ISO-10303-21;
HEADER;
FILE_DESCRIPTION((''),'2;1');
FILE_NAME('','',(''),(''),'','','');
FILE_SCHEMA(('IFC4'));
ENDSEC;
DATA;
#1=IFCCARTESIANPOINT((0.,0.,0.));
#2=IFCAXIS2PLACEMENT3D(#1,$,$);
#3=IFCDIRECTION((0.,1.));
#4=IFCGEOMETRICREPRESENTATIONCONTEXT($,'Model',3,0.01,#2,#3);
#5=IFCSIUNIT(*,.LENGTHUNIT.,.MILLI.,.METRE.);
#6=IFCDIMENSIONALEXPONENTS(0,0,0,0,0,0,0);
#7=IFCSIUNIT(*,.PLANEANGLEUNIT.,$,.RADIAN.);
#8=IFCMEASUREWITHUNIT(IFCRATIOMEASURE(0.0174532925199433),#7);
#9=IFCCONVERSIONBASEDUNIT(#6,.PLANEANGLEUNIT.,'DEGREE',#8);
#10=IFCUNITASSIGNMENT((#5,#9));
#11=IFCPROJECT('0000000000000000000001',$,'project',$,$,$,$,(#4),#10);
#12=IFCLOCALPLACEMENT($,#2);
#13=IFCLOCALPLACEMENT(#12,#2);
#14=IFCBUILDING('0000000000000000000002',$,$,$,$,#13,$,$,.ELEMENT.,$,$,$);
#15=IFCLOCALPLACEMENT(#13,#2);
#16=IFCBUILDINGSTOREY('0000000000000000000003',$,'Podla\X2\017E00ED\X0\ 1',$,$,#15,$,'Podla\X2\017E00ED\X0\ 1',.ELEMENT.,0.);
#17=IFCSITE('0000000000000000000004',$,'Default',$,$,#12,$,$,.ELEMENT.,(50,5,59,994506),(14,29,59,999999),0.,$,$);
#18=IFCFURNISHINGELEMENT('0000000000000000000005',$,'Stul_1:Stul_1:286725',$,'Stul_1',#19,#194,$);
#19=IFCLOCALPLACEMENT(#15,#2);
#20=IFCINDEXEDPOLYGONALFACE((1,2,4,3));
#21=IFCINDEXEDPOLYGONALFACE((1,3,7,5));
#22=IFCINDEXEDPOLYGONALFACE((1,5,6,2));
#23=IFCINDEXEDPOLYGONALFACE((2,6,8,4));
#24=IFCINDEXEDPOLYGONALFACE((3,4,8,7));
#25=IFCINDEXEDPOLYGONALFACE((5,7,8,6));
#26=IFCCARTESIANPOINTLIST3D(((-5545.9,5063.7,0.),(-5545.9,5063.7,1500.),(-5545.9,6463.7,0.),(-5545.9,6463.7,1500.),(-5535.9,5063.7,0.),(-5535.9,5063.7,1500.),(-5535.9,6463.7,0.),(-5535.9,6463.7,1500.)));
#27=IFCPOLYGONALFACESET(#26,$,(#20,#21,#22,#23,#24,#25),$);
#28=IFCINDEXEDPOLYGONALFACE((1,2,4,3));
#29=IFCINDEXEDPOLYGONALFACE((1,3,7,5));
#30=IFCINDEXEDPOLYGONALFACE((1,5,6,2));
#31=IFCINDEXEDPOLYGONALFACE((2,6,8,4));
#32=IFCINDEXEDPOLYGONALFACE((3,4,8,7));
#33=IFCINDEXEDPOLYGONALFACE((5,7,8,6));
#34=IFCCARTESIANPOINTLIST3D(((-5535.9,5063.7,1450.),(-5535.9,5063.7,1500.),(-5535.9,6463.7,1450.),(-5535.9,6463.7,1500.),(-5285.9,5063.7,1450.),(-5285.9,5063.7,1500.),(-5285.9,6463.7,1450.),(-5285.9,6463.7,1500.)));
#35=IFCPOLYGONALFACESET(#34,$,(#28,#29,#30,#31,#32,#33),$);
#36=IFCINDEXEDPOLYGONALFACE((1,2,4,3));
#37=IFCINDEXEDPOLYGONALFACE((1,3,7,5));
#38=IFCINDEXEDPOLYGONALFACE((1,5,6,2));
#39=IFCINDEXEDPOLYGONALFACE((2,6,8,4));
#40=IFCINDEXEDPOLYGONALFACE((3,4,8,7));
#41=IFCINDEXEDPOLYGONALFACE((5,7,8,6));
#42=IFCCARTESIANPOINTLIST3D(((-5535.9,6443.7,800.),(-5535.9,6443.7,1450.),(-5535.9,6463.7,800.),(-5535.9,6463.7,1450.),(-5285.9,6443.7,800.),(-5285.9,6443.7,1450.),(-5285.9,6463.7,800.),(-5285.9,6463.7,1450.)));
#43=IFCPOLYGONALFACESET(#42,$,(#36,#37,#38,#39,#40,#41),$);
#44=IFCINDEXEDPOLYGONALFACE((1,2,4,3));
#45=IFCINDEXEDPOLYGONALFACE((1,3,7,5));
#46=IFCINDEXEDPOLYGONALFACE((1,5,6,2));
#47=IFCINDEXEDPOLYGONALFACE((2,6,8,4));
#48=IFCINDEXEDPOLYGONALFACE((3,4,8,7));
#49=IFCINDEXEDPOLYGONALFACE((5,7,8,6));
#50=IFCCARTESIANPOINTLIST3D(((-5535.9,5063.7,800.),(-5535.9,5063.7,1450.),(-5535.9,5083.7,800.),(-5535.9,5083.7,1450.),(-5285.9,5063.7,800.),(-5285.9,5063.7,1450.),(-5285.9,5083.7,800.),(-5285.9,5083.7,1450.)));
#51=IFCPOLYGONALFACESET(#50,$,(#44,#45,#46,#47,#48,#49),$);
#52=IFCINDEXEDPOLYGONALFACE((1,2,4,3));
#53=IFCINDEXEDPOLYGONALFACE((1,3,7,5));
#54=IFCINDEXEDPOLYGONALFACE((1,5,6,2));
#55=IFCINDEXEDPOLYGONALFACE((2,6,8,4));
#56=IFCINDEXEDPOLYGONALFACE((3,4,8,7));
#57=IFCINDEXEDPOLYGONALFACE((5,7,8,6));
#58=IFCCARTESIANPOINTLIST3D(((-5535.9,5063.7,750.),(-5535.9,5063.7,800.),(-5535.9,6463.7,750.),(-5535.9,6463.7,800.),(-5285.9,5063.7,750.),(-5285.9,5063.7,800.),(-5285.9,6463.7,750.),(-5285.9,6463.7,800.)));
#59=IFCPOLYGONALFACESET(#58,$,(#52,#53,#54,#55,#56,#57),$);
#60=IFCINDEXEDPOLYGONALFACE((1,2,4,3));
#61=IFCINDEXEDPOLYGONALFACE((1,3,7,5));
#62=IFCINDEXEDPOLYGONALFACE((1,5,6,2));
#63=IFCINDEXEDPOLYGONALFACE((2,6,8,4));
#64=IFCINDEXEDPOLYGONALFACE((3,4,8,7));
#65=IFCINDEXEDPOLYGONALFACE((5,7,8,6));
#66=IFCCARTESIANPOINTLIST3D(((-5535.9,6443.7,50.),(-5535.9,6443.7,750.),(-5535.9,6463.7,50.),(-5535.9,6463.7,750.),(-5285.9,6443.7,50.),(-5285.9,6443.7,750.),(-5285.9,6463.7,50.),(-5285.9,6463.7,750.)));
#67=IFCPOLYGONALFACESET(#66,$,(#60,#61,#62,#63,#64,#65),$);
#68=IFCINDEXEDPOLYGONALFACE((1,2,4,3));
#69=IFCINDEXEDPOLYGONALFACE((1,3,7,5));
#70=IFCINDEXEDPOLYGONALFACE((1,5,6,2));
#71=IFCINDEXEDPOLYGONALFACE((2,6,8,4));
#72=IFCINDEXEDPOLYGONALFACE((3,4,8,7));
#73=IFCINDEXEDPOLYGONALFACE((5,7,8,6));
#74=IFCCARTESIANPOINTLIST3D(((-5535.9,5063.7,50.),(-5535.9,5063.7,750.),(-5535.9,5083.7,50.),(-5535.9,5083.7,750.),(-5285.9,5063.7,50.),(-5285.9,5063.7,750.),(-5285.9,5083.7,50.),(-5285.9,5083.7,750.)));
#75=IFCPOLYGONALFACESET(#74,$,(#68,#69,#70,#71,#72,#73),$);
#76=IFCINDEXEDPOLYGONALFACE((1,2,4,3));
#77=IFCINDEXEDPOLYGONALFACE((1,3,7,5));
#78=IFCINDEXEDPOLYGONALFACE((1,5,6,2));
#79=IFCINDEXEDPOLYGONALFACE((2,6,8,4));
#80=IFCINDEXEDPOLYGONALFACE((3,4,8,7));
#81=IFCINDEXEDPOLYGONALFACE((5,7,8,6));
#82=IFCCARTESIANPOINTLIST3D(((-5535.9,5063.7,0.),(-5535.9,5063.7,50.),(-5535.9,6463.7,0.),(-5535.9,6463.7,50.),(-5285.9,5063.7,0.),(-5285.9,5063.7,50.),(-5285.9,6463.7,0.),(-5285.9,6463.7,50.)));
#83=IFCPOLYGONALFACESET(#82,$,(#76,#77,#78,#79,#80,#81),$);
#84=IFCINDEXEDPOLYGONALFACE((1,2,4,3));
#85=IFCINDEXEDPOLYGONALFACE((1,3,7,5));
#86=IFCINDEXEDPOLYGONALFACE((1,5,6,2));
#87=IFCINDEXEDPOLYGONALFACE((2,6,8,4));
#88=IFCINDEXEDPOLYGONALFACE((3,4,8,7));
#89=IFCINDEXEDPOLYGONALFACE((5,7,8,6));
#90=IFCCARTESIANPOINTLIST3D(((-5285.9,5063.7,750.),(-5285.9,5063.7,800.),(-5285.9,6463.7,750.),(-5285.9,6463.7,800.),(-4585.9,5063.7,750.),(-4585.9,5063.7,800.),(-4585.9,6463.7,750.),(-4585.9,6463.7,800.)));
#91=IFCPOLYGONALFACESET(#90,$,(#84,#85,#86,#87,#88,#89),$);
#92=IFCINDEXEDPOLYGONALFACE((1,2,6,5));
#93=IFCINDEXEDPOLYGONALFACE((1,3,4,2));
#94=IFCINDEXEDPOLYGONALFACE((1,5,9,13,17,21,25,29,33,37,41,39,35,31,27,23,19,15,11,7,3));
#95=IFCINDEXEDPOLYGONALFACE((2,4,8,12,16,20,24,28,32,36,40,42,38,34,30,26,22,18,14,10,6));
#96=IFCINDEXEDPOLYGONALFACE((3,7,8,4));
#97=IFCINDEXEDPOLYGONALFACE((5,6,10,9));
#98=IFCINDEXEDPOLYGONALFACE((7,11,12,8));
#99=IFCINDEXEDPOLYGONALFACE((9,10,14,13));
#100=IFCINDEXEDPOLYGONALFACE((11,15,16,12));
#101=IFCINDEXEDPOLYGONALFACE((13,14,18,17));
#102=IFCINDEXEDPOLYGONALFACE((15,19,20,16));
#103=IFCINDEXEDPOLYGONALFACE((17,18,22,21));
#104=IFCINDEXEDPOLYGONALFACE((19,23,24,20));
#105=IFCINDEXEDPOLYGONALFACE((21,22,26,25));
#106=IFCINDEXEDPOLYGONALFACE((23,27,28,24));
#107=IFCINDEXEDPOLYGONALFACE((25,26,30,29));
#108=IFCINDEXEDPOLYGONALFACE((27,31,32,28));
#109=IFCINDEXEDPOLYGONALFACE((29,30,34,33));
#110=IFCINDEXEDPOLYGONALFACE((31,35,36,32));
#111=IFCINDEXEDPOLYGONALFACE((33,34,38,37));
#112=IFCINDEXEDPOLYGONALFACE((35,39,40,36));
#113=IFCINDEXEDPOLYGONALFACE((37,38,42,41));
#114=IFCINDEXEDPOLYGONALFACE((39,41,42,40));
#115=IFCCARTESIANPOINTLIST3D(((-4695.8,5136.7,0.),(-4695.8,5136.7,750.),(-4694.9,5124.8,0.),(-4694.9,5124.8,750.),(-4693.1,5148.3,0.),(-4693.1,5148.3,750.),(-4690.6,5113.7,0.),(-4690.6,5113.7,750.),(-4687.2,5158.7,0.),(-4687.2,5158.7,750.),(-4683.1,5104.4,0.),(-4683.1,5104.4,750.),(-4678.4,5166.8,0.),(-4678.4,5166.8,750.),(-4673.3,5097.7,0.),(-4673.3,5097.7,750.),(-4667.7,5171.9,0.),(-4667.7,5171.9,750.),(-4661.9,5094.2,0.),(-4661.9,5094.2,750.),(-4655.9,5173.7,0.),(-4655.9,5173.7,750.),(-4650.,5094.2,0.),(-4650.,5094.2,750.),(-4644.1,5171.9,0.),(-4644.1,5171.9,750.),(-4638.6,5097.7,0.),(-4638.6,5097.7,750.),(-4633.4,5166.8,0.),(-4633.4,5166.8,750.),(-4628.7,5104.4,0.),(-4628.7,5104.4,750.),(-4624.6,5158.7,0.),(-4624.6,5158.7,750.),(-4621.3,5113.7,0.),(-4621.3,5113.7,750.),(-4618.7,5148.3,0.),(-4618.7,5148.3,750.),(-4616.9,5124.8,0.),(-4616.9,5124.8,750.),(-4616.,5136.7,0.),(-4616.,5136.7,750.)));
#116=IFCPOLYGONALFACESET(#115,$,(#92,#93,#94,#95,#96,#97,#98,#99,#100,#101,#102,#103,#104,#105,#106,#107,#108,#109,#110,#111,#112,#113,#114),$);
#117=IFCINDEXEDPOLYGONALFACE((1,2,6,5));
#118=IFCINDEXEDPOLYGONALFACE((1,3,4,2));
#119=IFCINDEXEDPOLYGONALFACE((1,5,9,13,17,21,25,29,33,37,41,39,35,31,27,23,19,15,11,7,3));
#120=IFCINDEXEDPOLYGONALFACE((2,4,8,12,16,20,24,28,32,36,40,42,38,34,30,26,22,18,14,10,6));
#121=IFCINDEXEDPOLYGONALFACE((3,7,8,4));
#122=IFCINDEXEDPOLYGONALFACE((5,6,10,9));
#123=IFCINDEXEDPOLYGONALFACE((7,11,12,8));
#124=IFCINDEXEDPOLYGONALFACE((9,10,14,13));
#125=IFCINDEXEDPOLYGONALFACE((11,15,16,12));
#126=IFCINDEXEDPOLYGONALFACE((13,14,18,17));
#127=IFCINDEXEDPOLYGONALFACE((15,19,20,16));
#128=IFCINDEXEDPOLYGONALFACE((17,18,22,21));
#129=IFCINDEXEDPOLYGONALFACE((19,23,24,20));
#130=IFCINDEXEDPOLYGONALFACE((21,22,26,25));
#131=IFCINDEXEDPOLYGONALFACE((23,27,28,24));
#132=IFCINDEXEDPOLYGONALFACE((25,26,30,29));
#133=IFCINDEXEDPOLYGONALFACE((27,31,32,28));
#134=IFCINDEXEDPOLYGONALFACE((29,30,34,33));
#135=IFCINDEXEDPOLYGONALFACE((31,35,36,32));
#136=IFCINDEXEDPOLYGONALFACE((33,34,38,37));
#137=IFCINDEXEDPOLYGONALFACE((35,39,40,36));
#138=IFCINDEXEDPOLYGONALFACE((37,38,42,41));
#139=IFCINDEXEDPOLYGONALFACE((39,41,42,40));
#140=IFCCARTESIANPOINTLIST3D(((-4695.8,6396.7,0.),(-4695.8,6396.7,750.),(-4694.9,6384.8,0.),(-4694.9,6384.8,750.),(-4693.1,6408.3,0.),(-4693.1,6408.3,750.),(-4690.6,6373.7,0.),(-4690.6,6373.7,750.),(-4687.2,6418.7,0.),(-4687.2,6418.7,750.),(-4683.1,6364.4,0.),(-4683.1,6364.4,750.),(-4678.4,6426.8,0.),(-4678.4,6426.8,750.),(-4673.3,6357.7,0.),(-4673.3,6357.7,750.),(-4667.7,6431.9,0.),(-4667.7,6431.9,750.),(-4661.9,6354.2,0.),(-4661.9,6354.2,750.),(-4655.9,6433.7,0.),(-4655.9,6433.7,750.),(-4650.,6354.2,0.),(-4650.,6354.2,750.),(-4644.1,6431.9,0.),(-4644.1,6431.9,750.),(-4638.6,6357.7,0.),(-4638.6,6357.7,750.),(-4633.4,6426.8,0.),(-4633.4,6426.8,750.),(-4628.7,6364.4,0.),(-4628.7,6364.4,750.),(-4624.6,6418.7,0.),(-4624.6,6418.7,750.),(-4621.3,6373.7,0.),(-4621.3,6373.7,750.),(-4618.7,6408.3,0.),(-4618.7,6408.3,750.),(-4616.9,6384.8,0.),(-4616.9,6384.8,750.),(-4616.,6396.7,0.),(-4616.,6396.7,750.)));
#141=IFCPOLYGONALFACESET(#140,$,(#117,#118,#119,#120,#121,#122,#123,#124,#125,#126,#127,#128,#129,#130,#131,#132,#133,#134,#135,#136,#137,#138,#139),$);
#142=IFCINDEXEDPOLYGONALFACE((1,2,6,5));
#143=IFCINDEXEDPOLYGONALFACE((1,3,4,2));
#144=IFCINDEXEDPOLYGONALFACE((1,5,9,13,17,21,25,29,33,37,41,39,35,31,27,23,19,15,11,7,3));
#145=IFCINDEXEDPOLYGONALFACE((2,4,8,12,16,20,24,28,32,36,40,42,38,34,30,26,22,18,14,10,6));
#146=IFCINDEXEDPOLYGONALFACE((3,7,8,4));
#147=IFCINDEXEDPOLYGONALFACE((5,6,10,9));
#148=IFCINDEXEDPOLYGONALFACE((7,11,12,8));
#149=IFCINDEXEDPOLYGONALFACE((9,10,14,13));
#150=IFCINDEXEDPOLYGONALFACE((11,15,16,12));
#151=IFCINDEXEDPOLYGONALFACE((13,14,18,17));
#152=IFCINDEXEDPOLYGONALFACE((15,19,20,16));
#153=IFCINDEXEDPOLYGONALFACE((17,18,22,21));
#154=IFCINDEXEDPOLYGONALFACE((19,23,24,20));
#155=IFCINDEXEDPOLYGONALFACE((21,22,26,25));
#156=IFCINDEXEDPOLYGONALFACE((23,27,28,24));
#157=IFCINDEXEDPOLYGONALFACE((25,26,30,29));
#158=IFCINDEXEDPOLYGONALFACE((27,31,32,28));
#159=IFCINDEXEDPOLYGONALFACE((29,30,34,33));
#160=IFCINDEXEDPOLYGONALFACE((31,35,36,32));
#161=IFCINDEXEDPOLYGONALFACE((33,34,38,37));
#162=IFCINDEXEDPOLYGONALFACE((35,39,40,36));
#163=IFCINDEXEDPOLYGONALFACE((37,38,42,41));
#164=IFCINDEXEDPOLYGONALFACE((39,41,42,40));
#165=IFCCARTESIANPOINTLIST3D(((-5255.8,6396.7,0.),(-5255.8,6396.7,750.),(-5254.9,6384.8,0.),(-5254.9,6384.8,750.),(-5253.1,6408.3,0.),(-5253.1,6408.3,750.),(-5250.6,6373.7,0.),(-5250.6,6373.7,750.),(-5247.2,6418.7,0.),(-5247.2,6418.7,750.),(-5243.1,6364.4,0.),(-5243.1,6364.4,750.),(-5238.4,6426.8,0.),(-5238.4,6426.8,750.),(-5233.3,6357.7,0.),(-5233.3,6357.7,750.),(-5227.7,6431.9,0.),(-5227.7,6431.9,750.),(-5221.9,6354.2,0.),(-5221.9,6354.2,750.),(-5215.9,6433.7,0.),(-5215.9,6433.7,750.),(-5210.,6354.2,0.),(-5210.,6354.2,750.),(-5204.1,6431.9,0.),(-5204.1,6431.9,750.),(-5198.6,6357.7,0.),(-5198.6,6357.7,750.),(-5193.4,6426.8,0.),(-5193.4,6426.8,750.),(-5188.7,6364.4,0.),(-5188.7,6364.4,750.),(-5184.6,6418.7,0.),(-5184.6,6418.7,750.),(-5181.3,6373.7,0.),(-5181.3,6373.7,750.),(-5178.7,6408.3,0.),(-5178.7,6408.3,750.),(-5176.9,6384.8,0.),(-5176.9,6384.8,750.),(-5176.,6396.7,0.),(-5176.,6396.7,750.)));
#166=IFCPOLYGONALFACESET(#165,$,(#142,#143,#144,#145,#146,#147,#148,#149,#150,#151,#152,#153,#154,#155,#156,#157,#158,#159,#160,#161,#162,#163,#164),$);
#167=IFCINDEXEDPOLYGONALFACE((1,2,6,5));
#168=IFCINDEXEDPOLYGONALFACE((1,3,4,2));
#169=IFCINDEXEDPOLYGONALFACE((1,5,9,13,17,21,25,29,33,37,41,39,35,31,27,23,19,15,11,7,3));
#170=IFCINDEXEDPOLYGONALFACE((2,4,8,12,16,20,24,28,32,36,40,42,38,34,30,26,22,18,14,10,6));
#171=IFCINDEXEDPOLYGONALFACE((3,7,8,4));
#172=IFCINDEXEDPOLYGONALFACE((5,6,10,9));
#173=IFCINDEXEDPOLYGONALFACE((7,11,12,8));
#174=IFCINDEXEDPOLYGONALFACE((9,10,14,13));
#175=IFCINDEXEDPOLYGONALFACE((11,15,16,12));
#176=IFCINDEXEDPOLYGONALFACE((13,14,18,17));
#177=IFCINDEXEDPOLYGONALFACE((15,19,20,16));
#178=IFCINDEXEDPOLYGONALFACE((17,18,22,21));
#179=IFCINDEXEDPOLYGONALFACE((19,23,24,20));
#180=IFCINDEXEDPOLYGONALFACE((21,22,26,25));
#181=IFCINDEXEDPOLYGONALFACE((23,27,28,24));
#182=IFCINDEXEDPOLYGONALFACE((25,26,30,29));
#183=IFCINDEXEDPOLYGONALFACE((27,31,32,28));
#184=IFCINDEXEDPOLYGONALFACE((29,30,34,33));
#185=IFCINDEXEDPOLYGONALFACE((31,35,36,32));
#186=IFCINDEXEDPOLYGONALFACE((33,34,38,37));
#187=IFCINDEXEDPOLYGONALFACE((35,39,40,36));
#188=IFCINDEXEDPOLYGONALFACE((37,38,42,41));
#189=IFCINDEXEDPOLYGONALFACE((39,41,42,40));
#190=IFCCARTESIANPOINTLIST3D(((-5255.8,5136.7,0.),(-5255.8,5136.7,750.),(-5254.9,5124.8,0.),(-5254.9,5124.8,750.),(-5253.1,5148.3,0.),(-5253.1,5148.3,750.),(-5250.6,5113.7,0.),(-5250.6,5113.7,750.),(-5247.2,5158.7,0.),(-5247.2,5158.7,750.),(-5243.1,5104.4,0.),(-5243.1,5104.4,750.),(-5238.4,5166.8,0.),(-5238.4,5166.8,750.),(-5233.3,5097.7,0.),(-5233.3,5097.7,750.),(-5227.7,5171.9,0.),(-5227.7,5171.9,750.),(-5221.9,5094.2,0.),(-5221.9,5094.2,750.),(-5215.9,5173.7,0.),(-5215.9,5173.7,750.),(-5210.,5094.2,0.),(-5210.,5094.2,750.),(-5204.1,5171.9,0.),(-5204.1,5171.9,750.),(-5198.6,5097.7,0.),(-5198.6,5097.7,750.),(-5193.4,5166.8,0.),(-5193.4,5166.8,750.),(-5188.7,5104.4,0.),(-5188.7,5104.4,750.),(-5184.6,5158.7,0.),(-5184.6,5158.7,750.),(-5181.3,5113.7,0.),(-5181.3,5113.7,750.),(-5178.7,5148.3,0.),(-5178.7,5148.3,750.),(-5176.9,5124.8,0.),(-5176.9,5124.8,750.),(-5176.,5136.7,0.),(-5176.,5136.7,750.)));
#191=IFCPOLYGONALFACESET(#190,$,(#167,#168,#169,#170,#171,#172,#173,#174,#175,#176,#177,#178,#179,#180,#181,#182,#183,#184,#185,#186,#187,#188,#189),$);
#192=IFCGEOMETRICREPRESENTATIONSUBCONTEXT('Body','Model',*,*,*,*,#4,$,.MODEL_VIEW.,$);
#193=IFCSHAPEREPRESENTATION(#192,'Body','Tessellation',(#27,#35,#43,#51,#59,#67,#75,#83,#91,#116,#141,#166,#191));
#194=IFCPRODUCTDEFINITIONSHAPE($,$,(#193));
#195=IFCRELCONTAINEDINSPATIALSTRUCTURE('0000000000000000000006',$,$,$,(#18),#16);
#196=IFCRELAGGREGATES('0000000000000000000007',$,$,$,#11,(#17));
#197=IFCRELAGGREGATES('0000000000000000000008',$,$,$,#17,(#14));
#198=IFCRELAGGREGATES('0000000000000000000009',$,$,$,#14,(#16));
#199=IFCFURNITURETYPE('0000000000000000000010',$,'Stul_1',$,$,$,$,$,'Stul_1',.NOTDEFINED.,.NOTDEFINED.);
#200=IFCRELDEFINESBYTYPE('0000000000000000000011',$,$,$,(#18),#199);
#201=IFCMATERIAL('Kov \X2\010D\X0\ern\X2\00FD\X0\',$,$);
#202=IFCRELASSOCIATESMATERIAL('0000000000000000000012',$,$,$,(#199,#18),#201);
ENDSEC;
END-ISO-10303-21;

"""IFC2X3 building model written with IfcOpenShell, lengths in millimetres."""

from ifc_helpers import new_model, entity, si_unit, converted_unit, direction, frame, frame_2d, origin, origin_2d_with_axis, place, context, subcontext, project, spatial, rectangle, circle, extrude, source, transform, mapped, material, type_object, type_shapes, element, save


model = new_model("IFC2X3")

# Units and contexts
model_context = context("Model", 3, precision=0.01, world=origin(), true_north=direction((0.0, 1.0)))
body_context = subcontext(model_context, "Body", "Model", "MODEL_VIEW")
ifc_project = project(units=[si_unit("LENGTHUNIT", "METRE", prefix="MILLI"), converted_unit("PLANEANGLEUNIT", "DEGREE", entity("IfcRatioMeasure", 0.0174532925199433), si_unit("PLANEANGLEUNIT", "RADIAN"), dimensions=[0, 0, 0, 0, 0, 0, 0])], contexts=[model_context])

# Site, building, storey
site_placement = place(None, origin())
site = spatial("IfcSite", under=ifc_project, at=site_placement, Name="Default", CompositionType="ELEMENT", RefLatitude=(50, 5, 59, 994506), RefLongitude=(14, 29, 59, 999999), RefElevation=0.0)
building_placement = place(site_placement, origin())
building = spatial("IfcBuilding", under=site, at=building_placement, CompositionType="ELEMENT")
storey_placement = place(building_placement, origin())
storey = spatial("IfcBuildingStorey", under=building, at=storey_placement, Name="Podlaží 1", LongName="Podlaží 1", CompositionType="ELEMENT", Elevation=0.0)

# Furnishing element
ifc_material_1 = material(Name="Kov černý")
furniture_type = type_object("IfcFurnitureType", Name="Stul_1", ElementType="Stul_1", material=ifc_material_1)
shared_shape_1 = source(origin(), body_context, "Body", "SweptSolid", [
    extrude(rectangle(XDim=1400.0, YDim=10.0, at=origin_2d_with_axis()), frame((0.0, 605.0, 0.0), z_axis=(0.0, 0.0, 1.0), x_axis=(-1.0, 0.0, 0.0)), (0.0, 0.0, 1.0), 1500.0),
    extrude(rectangle(XDim=1400.0, YDim=250.0, at=frame_2d((0.0, 0.0), x_axis=(1.0, 0.0))), frame((0.0, 475.0, 1450.0), z_axis=(0.0, 0.0, 1.0), x_axis=(-1.0, 0.0, 0.0)), (0.0, 0.0, 1.0), 50.0),
    extrude(rectangle(XDim=20.0, YDim=250.0, at=origin_2d_with_axis()), frame((690.0, 475.0, 800.0), z_axis=(0.0, 0.0, 1.0), x_axis=(-1.0, 0.0, 0.0)), (0.0, 0.0, 1.0), 650.0),
    extrude(rectangle(XDim=20.0, YDim=250.0, at=frame_2d((0.0, 0.0), x_axis=(1.0, 0.0))), frame((-690.0, 475.0, 800.0), z_axis=(0.0, 0.0, 1.0), x_axis=(-1.0, 0.0, 0.0)), (0.0, 0.0, 1.0), 650.0),
    extrude(rectangle(XDim=1400.0, YDim=250.0, at=origin_2d_with_axis()), frame((0.0, 475.0, 750.0), z_axis=(0.0, 0.0, 1.0), x_axis=(-1.0, 0.0, 0.0)), (0.0, 0.0, 1.0), 50.0),
    extrude(rectangle(XDim=20.0, YDim=250.0, at=origin_2d_with_axis()), frame((690.0, 475.0, 50.0), z_axis=(0.0, 0.0, 1.0), x_axis=(-1.0, 0.0, 0.0)), (0.0, 0.0, 1.0), 700.0),
    extrude(rectangle(XDim=20.0, YDim=250.0, at=frame_2d((0.0, 0.0), x_axis=(1.0, 0.0))), frame((-690.0, 475.0, 50.0), z_axis=(0.0, 0.0, 1.0), x_axis=(-1.0, 0.0, 0.0)), (0.0, 0.0, 1.0), 700.0),
    extrude(rectangle(XDim=1400.0, YDim=250.0, at=origin_2d_with_axis()), frame((0.0, 475.0, 0.0), z_axis=(0.0, 0.0, 1.0), x_axis=(-1.0, 0.0, 0.0)), (0.0, 0.0, 1.0), 50.0),
    extrude(rectangle(XDim=1400.0, YDim=700.0, at=origin_2d_with_axis()), frame((0.0, 0.0, 750.0), z_axis=(0.0, 0.0, 1.0), x_axis=(-1.0, 0.0, 0.0)), (0.0, 0.0, 1.0), 50.0),
    extrude(circle(Radius=40.0, at=frame_2d((0.0, 0.0), x_axis=(1.0, 0.0))), frame((-630.0, -280.0, 0.0)), (0.0, 0.0, 1.0), 750.0),
    extrude(circle(Radius=40.0, at=frame_2d((0.0, 0.0), x_axis=(1.0, 0.0))), frame((630.0, -280.0, 0.0)), (0.0, 0.0, 1.0), 750.0),
    extrude(circle(Radius=40.0, at=frame_2d((0.0, 0.0), x_axis=(1.0, 0.0))), frame((630.0, 280.0, 0.0)), (0.0, 0.0, 1.0), 750.0),
    extrude(circle(Radius=40.0, at=frame_2d((0.0, 0.0), x_axis=(1.0, 0.0))), frame((-630.0, 280.0, 0.0)), (0.0, 0.0, 1.0), 750.0),
])
type_shapes(furniture_type, [shared_shape_1])
for number, where, z_axis, x_axis, name in (
    (1, (-4935.9, 5763.7, 0.0), (0.0, 0.0, 1.0), (0.0, 1.0, 0.0), "Stul_1:Stul_1:286725"),
):
    element("IfcFurnishingElement", number, at=place(storey_placement, frame(where, z_axis=z_axis, x_axis=x_axis)), inside=storey, type_object=furniture_type, material=ifc_material_1, Name=name, ObjectType="Stul_1", context=body_context, shape_type="MappedRepresentation", body=[
        mapped(shared_shape_1, transform((0.0, 0.0, 0.0), scale=1.0)),
    ])

save(model, "model.ifc")
